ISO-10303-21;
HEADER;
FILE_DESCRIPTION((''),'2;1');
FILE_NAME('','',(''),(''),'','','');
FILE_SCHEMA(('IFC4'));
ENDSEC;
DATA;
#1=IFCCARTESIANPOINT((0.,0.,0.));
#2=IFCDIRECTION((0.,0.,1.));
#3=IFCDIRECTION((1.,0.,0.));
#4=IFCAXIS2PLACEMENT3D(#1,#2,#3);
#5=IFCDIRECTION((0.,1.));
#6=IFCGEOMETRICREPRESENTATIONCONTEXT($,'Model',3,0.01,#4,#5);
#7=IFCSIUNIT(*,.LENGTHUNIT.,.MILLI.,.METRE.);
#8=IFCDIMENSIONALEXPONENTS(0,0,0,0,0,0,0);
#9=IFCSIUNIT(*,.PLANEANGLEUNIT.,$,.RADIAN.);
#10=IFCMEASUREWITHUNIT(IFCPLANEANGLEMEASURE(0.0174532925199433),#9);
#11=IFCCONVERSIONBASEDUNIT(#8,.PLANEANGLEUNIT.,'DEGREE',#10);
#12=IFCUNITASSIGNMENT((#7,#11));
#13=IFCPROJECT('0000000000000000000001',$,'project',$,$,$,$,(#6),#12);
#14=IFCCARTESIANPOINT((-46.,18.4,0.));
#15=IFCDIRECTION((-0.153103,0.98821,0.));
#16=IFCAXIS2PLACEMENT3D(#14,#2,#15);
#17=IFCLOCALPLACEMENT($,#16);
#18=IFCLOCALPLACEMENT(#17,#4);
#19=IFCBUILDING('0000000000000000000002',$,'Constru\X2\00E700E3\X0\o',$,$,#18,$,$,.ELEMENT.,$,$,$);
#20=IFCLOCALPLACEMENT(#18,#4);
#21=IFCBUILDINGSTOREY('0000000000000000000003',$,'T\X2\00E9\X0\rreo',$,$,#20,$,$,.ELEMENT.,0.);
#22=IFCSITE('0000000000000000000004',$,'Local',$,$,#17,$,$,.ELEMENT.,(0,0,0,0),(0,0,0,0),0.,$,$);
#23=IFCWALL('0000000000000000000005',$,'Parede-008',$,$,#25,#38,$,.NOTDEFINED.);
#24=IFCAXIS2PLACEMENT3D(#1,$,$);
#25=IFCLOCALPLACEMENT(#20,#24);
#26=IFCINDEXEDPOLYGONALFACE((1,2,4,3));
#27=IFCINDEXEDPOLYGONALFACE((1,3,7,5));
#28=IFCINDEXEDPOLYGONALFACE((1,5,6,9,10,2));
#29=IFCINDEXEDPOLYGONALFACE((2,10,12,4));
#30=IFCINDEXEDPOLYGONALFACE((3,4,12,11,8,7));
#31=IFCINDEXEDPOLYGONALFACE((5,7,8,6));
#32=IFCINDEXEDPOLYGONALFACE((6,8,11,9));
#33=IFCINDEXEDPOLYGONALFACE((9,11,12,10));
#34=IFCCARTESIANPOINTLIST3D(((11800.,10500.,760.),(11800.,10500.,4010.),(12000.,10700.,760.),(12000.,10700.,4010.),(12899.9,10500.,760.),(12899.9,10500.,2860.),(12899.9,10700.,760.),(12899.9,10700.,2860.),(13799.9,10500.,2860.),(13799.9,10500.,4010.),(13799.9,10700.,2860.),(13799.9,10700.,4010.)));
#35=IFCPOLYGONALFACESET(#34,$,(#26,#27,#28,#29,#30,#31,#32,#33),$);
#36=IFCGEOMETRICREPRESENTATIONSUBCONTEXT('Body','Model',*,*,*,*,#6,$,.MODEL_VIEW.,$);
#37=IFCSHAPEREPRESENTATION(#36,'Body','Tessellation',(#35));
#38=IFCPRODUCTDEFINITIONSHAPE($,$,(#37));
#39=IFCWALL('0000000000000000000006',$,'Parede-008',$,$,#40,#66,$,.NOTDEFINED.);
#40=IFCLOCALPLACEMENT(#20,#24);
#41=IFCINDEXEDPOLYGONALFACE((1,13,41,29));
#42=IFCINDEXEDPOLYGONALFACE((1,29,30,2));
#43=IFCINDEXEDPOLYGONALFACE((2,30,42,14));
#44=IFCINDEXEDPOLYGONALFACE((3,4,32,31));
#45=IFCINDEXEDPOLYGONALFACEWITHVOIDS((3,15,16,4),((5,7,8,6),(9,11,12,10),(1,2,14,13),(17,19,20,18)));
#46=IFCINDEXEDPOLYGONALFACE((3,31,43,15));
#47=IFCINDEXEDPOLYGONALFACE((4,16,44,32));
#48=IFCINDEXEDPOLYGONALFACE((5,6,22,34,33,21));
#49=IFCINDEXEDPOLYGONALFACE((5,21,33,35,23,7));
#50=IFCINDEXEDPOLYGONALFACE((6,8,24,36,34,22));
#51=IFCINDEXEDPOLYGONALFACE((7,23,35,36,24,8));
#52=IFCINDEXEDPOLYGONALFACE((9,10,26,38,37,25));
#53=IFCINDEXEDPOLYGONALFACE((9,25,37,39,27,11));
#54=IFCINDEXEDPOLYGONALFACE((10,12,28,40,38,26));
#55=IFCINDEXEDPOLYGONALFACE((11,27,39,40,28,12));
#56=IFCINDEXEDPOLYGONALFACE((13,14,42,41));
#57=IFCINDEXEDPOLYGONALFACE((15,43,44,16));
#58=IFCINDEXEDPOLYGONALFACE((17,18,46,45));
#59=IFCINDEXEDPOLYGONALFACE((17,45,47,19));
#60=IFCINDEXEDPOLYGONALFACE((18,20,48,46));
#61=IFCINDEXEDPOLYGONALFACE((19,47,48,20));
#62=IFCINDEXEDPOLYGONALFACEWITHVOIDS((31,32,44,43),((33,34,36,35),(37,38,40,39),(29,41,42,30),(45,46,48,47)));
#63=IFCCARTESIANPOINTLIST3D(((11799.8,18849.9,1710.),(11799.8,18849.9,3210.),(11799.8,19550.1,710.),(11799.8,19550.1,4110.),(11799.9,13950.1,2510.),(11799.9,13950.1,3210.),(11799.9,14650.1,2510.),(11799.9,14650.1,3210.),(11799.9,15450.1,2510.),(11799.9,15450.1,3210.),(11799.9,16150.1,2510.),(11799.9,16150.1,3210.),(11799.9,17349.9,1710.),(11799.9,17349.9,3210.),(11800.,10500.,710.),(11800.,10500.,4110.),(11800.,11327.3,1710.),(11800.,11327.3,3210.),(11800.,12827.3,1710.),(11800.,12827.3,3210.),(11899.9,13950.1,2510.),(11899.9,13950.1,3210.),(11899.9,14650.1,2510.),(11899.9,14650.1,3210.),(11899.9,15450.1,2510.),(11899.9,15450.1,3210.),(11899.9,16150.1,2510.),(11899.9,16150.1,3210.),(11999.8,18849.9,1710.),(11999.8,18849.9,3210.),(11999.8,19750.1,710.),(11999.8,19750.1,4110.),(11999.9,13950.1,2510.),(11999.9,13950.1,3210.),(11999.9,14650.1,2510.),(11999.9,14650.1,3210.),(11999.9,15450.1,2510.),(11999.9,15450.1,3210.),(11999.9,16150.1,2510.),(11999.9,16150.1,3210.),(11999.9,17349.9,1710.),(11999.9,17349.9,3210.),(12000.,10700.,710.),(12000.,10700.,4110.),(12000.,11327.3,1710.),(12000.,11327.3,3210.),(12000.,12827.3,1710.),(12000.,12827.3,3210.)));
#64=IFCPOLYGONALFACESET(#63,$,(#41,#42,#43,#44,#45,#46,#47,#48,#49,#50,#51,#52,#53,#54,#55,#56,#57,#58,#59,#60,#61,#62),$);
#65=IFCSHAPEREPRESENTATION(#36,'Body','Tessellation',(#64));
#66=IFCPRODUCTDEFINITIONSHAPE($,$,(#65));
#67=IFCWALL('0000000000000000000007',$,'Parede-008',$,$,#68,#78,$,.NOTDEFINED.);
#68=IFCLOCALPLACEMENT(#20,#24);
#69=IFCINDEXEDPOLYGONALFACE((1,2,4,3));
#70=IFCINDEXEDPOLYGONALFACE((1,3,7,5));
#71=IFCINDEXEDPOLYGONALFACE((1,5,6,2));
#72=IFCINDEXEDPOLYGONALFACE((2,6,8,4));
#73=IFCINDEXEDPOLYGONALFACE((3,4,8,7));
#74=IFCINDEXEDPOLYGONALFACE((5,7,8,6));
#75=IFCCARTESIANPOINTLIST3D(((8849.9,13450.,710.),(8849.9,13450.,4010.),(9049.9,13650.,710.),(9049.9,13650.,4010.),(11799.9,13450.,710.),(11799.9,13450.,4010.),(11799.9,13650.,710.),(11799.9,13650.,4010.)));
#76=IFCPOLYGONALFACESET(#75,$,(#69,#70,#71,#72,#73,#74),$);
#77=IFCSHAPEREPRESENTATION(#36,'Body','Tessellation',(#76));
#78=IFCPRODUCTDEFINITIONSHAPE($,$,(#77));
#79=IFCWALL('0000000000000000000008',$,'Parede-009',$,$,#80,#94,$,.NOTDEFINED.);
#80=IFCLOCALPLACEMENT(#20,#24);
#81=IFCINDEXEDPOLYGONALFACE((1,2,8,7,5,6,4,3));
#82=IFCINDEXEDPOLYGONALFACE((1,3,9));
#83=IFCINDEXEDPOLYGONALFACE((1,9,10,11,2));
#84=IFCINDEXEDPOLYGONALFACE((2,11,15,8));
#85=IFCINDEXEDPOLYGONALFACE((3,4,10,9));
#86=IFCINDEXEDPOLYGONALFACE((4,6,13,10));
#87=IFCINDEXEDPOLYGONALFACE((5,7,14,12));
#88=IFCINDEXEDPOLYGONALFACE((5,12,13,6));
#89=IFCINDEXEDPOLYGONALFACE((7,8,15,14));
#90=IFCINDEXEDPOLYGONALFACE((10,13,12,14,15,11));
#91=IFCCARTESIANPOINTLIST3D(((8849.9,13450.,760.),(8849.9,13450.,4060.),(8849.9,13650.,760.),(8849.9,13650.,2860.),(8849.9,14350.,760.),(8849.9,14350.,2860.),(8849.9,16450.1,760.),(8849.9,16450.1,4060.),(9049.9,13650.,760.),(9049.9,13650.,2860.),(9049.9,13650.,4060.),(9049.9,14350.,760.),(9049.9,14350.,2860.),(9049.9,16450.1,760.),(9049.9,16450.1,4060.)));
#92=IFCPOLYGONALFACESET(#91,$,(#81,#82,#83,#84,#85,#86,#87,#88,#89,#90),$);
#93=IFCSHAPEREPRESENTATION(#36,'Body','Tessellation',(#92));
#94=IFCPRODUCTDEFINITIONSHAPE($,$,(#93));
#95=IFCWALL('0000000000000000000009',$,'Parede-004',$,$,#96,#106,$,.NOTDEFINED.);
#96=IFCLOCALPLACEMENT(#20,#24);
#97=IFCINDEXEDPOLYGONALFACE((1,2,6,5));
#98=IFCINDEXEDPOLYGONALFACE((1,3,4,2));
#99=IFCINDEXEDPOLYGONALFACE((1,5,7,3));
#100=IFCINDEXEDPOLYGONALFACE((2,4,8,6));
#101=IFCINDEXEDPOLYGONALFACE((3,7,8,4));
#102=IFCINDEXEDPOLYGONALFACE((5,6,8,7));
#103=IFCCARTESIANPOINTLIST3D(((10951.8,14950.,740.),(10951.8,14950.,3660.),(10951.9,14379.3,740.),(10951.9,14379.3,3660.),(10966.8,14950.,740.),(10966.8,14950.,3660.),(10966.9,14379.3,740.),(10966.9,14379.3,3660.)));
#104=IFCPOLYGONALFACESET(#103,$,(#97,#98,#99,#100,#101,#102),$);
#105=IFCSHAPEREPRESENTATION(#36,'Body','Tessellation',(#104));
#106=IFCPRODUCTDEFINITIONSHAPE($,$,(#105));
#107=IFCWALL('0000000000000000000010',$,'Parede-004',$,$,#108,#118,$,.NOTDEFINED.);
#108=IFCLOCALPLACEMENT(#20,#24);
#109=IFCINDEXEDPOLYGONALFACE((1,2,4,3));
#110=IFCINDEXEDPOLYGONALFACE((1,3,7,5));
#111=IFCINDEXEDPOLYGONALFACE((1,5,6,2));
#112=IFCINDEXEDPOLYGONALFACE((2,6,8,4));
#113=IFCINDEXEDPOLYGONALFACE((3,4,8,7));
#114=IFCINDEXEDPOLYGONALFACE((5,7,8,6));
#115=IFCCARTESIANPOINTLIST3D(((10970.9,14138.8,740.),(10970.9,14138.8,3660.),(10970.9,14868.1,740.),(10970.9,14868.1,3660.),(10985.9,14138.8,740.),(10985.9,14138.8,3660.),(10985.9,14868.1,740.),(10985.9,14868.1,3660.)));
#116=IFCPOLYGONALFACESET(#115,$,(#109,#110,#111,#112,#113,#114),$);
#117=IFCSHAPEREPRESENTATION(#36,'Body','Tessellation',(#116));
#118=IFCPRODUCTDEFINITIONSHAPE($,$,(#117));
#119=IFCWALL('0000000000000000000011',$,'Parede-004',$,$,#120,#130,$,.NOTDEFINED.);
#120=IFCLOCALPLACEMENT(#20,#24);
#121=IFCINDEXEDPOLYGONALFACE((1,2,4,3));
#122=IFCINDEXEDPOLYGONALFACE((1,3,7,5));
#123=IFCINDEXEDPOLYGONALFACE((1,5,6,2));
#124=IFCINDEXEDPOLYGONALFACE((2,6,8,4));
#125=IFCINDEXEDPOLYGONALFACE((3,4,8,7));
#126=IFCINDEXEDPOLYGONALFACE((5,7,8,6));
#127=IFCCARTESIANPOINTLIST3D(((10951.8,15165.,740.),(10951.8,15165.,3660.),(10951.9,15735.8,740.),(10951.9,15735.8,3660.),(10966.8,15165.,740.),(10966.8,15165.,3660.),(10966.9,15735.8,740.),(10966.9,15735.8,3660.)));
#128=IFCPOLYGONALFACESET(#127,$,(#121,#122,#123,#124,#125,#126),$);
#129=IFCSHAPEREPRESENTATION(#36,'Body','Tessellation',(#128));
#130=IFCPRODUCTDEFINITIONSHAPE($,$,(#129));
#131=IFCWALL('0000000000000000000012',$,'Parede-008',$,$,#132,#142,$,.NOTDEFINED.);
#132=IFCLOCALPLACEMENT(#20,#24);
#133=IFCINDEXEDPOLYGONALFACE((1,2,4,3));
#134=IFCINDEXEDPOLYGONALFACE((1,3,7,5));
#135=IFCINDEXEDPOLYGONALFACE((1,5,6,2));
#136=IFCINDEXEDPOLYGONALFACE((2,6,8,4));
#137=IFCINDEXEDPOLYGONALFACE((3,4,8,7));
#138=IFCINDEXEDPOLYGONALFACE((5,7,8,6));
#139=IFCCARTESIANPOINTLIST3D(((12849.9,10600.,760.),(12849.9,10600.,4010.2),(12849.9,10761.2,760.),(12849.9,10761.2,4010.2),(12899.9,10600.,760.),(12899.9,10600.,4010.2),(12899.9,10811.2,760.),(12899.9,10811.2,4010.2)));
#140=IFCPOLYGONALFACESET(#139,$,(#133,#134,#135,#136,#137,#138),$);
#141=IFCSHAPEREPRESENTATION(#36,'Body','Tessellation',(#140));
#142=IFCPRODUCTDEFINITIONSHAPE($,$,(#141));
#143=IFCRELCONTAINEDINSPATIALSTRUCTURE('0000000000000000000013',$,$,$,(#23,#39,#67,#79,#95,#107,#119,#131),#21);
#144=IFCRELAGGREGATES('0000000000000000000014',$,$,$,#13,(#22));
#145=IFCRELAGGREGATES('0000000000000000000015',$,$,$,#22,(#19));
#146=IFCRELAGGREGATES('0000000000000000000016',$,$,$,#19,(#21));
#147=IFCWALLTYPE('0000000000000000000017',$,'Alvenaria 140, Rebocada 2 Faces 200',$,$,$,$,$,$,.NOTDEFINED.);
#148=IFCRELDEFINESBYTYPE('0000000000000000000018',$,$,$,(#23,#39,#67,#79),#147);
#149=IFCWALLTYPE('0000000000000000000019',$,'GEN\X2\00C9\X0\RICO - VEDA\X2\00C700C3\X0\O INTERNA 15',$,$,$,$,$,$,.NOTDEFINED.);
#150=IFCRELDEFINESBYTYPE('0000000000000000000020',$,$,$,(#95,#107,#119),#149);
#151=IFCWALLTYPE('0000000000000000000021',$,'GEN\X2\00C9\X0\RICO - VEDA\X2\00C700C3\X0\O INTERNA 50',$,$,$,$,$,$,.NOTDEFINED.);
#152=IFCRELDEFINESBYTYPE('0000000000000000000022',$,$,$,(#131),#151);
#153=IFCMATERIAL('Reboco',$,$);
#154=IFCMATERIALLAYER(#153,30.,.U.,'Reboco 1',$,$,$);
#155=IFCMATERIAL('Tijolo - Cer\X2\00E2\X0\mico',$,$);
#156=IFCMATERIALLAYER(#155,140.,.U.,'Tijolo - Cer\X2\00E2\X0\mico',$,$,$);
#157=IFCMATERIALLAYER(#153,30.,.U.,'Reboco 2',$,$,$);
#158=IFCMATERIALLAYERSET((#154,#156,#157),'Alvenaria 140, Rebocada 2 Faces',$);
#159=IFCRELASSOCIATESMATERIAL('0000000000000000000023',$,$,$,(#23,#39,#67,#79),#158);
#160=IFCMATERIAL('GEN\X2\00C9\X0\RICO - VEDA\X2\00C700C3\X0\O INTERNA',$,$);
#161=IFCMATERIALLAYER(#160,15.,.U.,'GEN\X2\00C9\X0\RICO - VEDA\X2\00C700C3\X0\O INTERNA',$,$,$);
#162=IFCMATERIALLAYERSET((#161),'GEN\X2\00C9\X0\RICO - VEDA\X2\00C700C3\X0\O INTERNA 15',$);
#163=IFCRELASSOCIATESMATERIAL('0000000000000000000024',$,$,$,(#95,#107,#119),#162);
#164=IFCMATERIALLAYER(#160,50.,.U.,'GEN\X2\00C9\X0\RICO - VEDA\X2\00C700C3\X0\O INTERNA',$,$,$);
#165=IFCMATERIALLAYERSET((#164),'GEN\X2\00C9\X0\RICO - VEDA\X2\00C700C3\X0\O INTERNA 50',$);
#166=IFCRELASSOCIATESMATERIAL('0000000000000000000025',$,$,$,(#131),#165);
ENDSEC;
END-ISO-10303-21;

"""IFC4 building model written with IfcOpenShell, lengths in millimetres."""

from ifc_helpers import new_model, entity, si_unit, converted_unit, direction, frame, origin_with_axes, origin_2d_with_axis, place, context, subcontext, project, spatial, line, indexed_curve, rectangle, outline, extrude, material, layer, layer_set, layer_usage, type_object, element, save


model = new_model("IFC4")

# Units and contexts
model_context = context("Model", 3, precision=0.01, world=origin_with_axes(), true_north=direction((0.0, 1.0)))
body_context = subcontext(model_context, "Body", "Model", "MODEL_VIEW")
ifc_project = project(units=[si_unit("LENGTHUNIT", "METRE", prefix="MILLI"), converted_unit("PLANEANGLEUNIT", "DEGREE", entity("IfcPlaneAngleMeasure", 0.0174532925199433), si_unit("PLANEANGLEUNIT", "RADIAN"), dimensions=[0, 0, 0, 0, 0, 0, 0])], contexts=[model_context])

# Site, building, storey
site_placement = place(None, frame((-46.0, 18.4, 0.0), z_axis=(0.0, 0.0, 1.0), x_axis=(-0.153103, 0.98821, 0.0)))
site = spatial("IfcSite", under=ifc_project, at=site_placement, Name="Local", CompositionType="ELEMENT", RefLatitude=(0, 0, 0, 0), RefLongitude=(0, 0, 0, 0), RefElevation=0.0)
building_placement = place(site_placement, origin_with_axes())
building = spatial("IfcBuilding", under=site, at=building_placement, Name="Construção", CompositionType="ELEMENT")
storey_placement = place(building_placement, origin_with_axes())
storey = spatial("IfcBuildingStorey", under=building, at=storey_placement, Name="Térreo", CompositionType="ELEMENT", Elevation=0.0)

# Wall, opening
ifc_material_1 = material(Name="Reboco")
ifc_layer_1 = layer(ifc_material_1, 30.0, ventilated="UNKNOWN", Name="Reboco 1")
ifc_material_2 = material(Name="Tijolo - Cerâmico")
ifc_layer_2 = layer(ifc_material_2, 140.0, ventilated="UNKNOWN", Name="Tijolo - Cerâmico")
ifc_layer_3 = layer(ifc_material_1, 30.0, ventilated="UNKNOWN", Name="Reboco 2")
ifc_layer_set_1 = layer_set([ifc_layer_1, ifc_layer_2, ifc_layer_3], Name="Alvenaria 140, Rebocada 2 Faces")
ifc_layer_usage_1 = layer_usage(ifc_layer_set_1, "AXIS2", "NEGATIVE", 0.0)
wall_type_1 = type_object("IfcWallType", Name="Alvenaria 140, Rebocada 2 Faces 200", PredefinedType="NOTDEFINED")
wall_1_placement = place(storey_placement, frame((13799.9, 10500.0, 760.0), z_axis=(0.0, 0.0, 1.0), x_axis=(-1.0, -0.000002, 0.0)))
wall_1 = element("IfcWall", 1, at=wall_1_placement, inside=storey, type_object=wall_type_1, material=ifc_layer_usage_1, Name="Parede-008", PredefinedType="NOTDEFINED", context=body_context, shape_type="SweptSolid", body=[
    extrude(outline(indexed_curve([(0.0, -200.0), (1799.9, -200.0), (1999.9, 0.0), (0.0, 0.0)], segments=[line(1, 2, 3, 4, 1)])), origin_with_axes(), (0.0, 0.0, 1.0), 3250.0),
])
opening_1_placement = place(wall_1_placement, frame((450.0, 0.0, 0.0), z_axis=(0.0, 0.0, 1.0), x_axis=(1.0, 0.0, 0.0)))
element("IfcOpeningElement", 2, at=opening_1_placement, cuts=wall_1, context=body_context, shape_type="SweptSolid", body=[
    extrude(rectangle(XDim=900.0, YDim=2100.0, at=origin_2d_with_axis()), frame((0.0, 200.0, 1050.0), z_axis=(0.0, -1.0, 0.0), x_axis=(-1.0, 0.0, 0.0)), (0.0, 0.0, 1.0), 600.0),
])

# Wall, openings
ifc_layer_usage_2 = layer_usage(ifc_layer_set_1, "AXIS2", "POSITIVE", 0.0)
wall_2_placement = place(storey_placement, frame((12000.0, 10500.0, 710.0), z_axis=(0.0, 0.0, 1.0), x_axis=(-0.00002, 1.0, 0.0)))
wall_2 = element("IfcWall", 3, at=wall_2_placement, inside=storey, type_object=wall_type_1, material=ifc_layer_usage_2, Name="Parede-008", PredefinedType="NOTDEFINED", context=body_context, shape_type="SweptSolid", body=[
    extrude(outline(indexed_curve([(200.0, 0.0), (9250.1, 0.0), (9050.1, 200.0), (0.0, 200.0)], segments=[line(1, 2, 3, 4, 1)])), origin_with_axes(), (0.0, 0.0, 1.0), 3400.0),
])
opening_2_placement = place(wall_2_placement, frame((7599.9, 0.0, 1000.0), z_axis=(0.0, 0.0, 1.0), x_axis=(1.0, 0.0, 0.0)))
element("IfcOpeningElement", 4, at=opening_2_placement, cuts=wall_2, context=body_context, shape_type="SweptSolid", body=[
    extrude(rectangle(XDim=1500.0, YDim=1500.0, at=origin_2d_with_axis()), frame((0.0, 200.0, 750.0), z_axis=(0.0, -1.0, 0.0), x_axis=(-1.0, 0.0, 0.0)), (0.0, 0.0, 1.0), 400.0),
    extrude(rectangle(XDim=1500.0, YDim=1500.0, at=origin_2d_with_axis()), frame((0.0, 200.0, 750.0), z_axis=(0.0, 1.0, 0.0), x_axis=(-1.0, 0.0, 0.0)), (0.0, 0.0, 1.0), 400.0),
])
opening_3_placement = place(wall_2_placement, frame((3800.1, 0.0, 1800.0), z_axis=(0.0, 0.0, 1.0), x_axis=(1.0, 0.0, 0.0)))
element("IfcOpeningElement", 5, at=opening_3_placement, cuts=wall_2, context=body_context, shape_type="SweptSolid", body=[
    extrude(rectangle(XDim=700.0, YDim=700.0, at=origin_2d_with_axis()), frame((0.0, 100.0, 350.0), z_axis=(0.0, 1.0, 0.0), x_axis=(1.0, 0.0, 0.0)), (0.0, 0.0, -1.0), 300.0),
    extrude(rectangle(XDim=700.0, YDim=700.0, at=origin_2d_with_axis()), frame((0.0, 100.0, 350.0), z_axis=(0.0, -1.0, 0.0), x_axis=(1.0, 0.0, 0.0)), (0.0, 0.0, -1.0), 300.0),
])
opening_4_placement = place(wall_2_placement, frame((5300.1, 0.0, 1800.0), z_axis=(0.0, 0.0, 1.0), x_axis=(1.0, 0.0, 0.0)))
element("IfcOpeningElement", 6, at=opening_4_placement, cuts=wall_2, context=body_context, shape_type="SweptSolid", body=[
    extrude(rectangle(XDim=700.0, YDim=700.0, at=origin_2d_with_axis()), frame((0.0, 100.0, 350.0), z_axis=(0.0, 1.0, 0.0), x_axis=(1.0, 0.0, 0.0)), (0.0, 0.0, -1.0), 300.0),
    extrude(rectangle(XDim=700.0, YDim=700.0, at=origin_2d_with_axis()), frame((0.0, 100.0, 350.0), z_axis=(0.0, -1.0, 0.0), x_axis=(1.0, 0.0, 0.0)), (0.0, 0.0, -1.0), 300.0),
])
opening_5_placement = place(wall_2_placement, frame((1577.2, 0.0, 1000.0), z_axis=(0.0, 0.0, 1.0), x_axis=(1.0, 0.0, 0.0)))
element("IfcOpeningElement", 7, at=opening_5_placement, cuts=wall_2, context=body_context, shape_type="SweptSolid", body=[
    extrude(rectangle(XDim=1500.0, YDim=1500.0, at=origin_2d_with_axis()), frame((0.0, 200.0, 750.0), z_axis=(0.0, -1.0, 0.0), x_axis=(-1.0, 0.0, 0.0)), (0.0, 0.0, 1.0), 400.0),
    extrude(rectangle(XDim=1500.0, YDim=1500.0, at=origin_2d_with_axis()), frame((0.0, 200.0, 750.0), z_axis=(0.0, 1.0, 0.0), x_axis=(-1.0, 0.0, 0.0)), (0.0, 0.0, 1.0), 400.0),
])

# Wall
ifc_layer_usage_3 = layer_usage(ifc_layer_set_1, "AXIS2", "NEGATIVE", 0.0)
wall_3_placement = place(storey_placement, frame((11999.9, 13450.0, 710.0), z_axis=(0.0, 0.0, 1.0), x_axis=(-1.0, -0.000002, 0.0)))
element("IfcWall", 8, at=wall_3_placement, inside=storey, type_object=wall_type_1, material=ifc_layer_usage_3, Name="Parede-008", PredefinedType="NOTDEFINED", context=body_context, shape_type="SweptSolid", body=[
    extrude(outline(indexed_curve([(200.0, -200.0), (2950.0, -200.0), (3150.0, 0.0), (200.0, 0.0)], segments=[line(1, 2, 3, 4, 1)])), origin_with_axes(), (0.0, 0.0, 1.0), 3300.0),
])

# Wall, opening
ifc_layer_usage_4 = layer_usage(ifc_layer_set_1, "AXIS2", "NEGATIVE", 0.0)
wall_4_placement = place(storey_placement, frame((8849.9, 13450.0, 760.0), z_axis=(0.0, 0.0, 1.0), x_axis=(-0.000002, 1.0, 0.0)))
wall_4 = element("IfcWall", 9, at=wall_4_placement, inside=storey, type_object=wall_type_1, material=ifc_layer_usage_4, Name="Parede-009", PredefinedType="NOTDEFINED", context=body_context, shape_type="SweptSolid", body=[
    extrude(outline(indexed_curve([(200.0, -200.0), (3000.1, -200.0), (3000.1, 0.0), (0.0, 0.0)], segments=[line(1, 2, 3, 4, 1)])), origin_with_axes(), (0.0, 0.0, 1.0), 3300.0),
])
opening_6_placement = place(wall_4_placement, frame((550.0, 0.0, 0.0), z_axis=(0.0, 0.0, 1.0), x_axis=(1.0, 0.0, 0.0)))
element("IfcOpeningElement", 10, at=opening_6_placement, cuts=wall_4, context=body_context, shape_type="SweptSolid", body=[
    extrude(rectangle(XDim=700.0, YDim=2100.0, at=origin_2d_with_axis()), frame((0.0, -200.0, 1050.0), z_axis=(0.0, 1.0, 0.0), x_axis=(-1.0, 0.0, 0.0)), (0.0, 0.0, 1.0), 600.0),
])

# Walls
ifc_material_3 = material(Name="GENÉRICO - VEDAÇÃO INTERNA")
ifc_layer_4 = layer(ifc_material_3, 15.0, ventilated="UNKNOWN", Name="GENÉRICO - VEDAÇÃO INTERNA")
ifc_layer_set_2 = layer_set([ifc_layer_4], Name="GENÉRICO - VEDAÇÃO INTERNA 15")
ifc_layer_usage_5 = layer_usage(ifc_layer_set_2, "AXIS2", "NEGATIVE", 15.0)
wall_type_2 = type_object("IfcWallType", Name="GENÉRICO - VEDAÇÃO INTERNA 15", PredefinedType="NOTDEFINED")
wall_5_placement = place(storey_placement, frame((10951.8, 14950.0, 740.0), z_axis=(0.0, 0.0, 1.0), x_axis=(0.000038, -1.0, 0.0)))
element("IfcWall", 11, at=wall_5_placement, inside=storey, type_object=wall_type_2, material=ifc_layer_usage_5, Name="Parede-004", PredefinedType="NOTDEFINED", context=body_context, shape_type="SweptSolid", body=[
    extrude(outline(indexed_curve([(0.0, 0.0), (570.7, 0.0), (570.7, 15.0), (0.0, 15.0)], segments=[line(1, 2, 3, 4, 1)])), origin_with_axes(), (0.0, 0.0, 1.0), 2920.0),
])
ifc_layer_usage_6 = layer_usage(ifc_layer_set_2, "AXIS2", "NEGATIVE", 15.0)
wall_6_placement = place(storey_placement, frame((10970.9, 14868.1, 740.0), z_axis=(0.0, 0.0, 1.0), x_axis=(0.000038, -1.0, 0.0)))
element("IfcWall", 12, at=wall_6_placement, inside=storey, type_object=wall_type_2, material=ifc_layer_usage_6, Name="Parede-004", PredefinedType="NOTDEFINED", context=body_context, shape_type="SweptSolid", body=[
    extrude(outline(indexed_curve([(0.0, 0.0), (729.3, 0.0), (729.3, 15.0), (0.0, 15.0)], segments=[line(1, 2, 3, 4, 1)])), origin_with_axes(), (0.0, 0.0, 1.0), 2920.0),
])
ifc_layer_usage_7 = layer_usage(ifc_layer_set_2, "AXIS2", "POSITIVE", -15.0)
wall_7_placement = place(storey_placement, frame((10951.8, 15165.0, 740.0), z_axis=(0.0, 0.0, 1.0), x_axis=(0.000034, 1.0, 0.0)))
element("IfcWall", 13, at=wall_7_placement, inside=storey, type_object=wall_type_2, material=ifc_layer_usage_7, Name="Parede-004", PredefinedType="NOTDEFINED", context=body_context, shape_type="SweptSolid", body=[
    extrude(outline(indexed_curve([(0.0, -15.0), (570.7, -15.0), (570.7, 0.0), (0.0, 0.0)], segments=[line(1, 2, 3, 4, 1)])), origin_with_axes(), (0.0, 0.0, 1.0), 2920.0),
])
ifc_layer_5 = layer(ifc_material_3, 50.0, ventilated="UNKNOWN", Name="GENÉRICO - VEDAÇÃO INTERNA")
ifc_layer_set_3 = layer_set([ifc_layer_5], Name="GENÉRICO - VEDAÇÃO INTERNA 50")
ifc_layer_usage_8 = layer_usage(ifc_layer_set_3, "AXIS2", "POSITIVE", 0.0)
wall_type_3 = type_object("IfcWallType", Name="GENÉRICO - VEDAÇÃO INTERNA 50", PredefinedType="NOTDEFINED")
wall_8_placement = place(storey_placement, frame((12899.9, 10600.0, 760.0), z_axis=(0.0, 0.0, 1.0), x_axis=(0.000015, 1.0, 0.0)))
element("IfcWall", 14, at=wall_8_placement, inside=storey, type_object=wall_type_3, material=ifc_layer_usage_8, Name="Parede-008", PredefinedType="NOTDEFINED", context=body_context, shape_type="SweptSolid", body=[
    extrude(outline(indexed_curve([(0.0, 0.0), (211.2, 0.0), (161.2, 50.0), (0.0, 50.0)], segments=[line(1, 2, 3, 4, 1)])), origin_with_axes(), (0.0, 0.0, 1.0), 3250.2),
])

save(model, "model.ifc")
